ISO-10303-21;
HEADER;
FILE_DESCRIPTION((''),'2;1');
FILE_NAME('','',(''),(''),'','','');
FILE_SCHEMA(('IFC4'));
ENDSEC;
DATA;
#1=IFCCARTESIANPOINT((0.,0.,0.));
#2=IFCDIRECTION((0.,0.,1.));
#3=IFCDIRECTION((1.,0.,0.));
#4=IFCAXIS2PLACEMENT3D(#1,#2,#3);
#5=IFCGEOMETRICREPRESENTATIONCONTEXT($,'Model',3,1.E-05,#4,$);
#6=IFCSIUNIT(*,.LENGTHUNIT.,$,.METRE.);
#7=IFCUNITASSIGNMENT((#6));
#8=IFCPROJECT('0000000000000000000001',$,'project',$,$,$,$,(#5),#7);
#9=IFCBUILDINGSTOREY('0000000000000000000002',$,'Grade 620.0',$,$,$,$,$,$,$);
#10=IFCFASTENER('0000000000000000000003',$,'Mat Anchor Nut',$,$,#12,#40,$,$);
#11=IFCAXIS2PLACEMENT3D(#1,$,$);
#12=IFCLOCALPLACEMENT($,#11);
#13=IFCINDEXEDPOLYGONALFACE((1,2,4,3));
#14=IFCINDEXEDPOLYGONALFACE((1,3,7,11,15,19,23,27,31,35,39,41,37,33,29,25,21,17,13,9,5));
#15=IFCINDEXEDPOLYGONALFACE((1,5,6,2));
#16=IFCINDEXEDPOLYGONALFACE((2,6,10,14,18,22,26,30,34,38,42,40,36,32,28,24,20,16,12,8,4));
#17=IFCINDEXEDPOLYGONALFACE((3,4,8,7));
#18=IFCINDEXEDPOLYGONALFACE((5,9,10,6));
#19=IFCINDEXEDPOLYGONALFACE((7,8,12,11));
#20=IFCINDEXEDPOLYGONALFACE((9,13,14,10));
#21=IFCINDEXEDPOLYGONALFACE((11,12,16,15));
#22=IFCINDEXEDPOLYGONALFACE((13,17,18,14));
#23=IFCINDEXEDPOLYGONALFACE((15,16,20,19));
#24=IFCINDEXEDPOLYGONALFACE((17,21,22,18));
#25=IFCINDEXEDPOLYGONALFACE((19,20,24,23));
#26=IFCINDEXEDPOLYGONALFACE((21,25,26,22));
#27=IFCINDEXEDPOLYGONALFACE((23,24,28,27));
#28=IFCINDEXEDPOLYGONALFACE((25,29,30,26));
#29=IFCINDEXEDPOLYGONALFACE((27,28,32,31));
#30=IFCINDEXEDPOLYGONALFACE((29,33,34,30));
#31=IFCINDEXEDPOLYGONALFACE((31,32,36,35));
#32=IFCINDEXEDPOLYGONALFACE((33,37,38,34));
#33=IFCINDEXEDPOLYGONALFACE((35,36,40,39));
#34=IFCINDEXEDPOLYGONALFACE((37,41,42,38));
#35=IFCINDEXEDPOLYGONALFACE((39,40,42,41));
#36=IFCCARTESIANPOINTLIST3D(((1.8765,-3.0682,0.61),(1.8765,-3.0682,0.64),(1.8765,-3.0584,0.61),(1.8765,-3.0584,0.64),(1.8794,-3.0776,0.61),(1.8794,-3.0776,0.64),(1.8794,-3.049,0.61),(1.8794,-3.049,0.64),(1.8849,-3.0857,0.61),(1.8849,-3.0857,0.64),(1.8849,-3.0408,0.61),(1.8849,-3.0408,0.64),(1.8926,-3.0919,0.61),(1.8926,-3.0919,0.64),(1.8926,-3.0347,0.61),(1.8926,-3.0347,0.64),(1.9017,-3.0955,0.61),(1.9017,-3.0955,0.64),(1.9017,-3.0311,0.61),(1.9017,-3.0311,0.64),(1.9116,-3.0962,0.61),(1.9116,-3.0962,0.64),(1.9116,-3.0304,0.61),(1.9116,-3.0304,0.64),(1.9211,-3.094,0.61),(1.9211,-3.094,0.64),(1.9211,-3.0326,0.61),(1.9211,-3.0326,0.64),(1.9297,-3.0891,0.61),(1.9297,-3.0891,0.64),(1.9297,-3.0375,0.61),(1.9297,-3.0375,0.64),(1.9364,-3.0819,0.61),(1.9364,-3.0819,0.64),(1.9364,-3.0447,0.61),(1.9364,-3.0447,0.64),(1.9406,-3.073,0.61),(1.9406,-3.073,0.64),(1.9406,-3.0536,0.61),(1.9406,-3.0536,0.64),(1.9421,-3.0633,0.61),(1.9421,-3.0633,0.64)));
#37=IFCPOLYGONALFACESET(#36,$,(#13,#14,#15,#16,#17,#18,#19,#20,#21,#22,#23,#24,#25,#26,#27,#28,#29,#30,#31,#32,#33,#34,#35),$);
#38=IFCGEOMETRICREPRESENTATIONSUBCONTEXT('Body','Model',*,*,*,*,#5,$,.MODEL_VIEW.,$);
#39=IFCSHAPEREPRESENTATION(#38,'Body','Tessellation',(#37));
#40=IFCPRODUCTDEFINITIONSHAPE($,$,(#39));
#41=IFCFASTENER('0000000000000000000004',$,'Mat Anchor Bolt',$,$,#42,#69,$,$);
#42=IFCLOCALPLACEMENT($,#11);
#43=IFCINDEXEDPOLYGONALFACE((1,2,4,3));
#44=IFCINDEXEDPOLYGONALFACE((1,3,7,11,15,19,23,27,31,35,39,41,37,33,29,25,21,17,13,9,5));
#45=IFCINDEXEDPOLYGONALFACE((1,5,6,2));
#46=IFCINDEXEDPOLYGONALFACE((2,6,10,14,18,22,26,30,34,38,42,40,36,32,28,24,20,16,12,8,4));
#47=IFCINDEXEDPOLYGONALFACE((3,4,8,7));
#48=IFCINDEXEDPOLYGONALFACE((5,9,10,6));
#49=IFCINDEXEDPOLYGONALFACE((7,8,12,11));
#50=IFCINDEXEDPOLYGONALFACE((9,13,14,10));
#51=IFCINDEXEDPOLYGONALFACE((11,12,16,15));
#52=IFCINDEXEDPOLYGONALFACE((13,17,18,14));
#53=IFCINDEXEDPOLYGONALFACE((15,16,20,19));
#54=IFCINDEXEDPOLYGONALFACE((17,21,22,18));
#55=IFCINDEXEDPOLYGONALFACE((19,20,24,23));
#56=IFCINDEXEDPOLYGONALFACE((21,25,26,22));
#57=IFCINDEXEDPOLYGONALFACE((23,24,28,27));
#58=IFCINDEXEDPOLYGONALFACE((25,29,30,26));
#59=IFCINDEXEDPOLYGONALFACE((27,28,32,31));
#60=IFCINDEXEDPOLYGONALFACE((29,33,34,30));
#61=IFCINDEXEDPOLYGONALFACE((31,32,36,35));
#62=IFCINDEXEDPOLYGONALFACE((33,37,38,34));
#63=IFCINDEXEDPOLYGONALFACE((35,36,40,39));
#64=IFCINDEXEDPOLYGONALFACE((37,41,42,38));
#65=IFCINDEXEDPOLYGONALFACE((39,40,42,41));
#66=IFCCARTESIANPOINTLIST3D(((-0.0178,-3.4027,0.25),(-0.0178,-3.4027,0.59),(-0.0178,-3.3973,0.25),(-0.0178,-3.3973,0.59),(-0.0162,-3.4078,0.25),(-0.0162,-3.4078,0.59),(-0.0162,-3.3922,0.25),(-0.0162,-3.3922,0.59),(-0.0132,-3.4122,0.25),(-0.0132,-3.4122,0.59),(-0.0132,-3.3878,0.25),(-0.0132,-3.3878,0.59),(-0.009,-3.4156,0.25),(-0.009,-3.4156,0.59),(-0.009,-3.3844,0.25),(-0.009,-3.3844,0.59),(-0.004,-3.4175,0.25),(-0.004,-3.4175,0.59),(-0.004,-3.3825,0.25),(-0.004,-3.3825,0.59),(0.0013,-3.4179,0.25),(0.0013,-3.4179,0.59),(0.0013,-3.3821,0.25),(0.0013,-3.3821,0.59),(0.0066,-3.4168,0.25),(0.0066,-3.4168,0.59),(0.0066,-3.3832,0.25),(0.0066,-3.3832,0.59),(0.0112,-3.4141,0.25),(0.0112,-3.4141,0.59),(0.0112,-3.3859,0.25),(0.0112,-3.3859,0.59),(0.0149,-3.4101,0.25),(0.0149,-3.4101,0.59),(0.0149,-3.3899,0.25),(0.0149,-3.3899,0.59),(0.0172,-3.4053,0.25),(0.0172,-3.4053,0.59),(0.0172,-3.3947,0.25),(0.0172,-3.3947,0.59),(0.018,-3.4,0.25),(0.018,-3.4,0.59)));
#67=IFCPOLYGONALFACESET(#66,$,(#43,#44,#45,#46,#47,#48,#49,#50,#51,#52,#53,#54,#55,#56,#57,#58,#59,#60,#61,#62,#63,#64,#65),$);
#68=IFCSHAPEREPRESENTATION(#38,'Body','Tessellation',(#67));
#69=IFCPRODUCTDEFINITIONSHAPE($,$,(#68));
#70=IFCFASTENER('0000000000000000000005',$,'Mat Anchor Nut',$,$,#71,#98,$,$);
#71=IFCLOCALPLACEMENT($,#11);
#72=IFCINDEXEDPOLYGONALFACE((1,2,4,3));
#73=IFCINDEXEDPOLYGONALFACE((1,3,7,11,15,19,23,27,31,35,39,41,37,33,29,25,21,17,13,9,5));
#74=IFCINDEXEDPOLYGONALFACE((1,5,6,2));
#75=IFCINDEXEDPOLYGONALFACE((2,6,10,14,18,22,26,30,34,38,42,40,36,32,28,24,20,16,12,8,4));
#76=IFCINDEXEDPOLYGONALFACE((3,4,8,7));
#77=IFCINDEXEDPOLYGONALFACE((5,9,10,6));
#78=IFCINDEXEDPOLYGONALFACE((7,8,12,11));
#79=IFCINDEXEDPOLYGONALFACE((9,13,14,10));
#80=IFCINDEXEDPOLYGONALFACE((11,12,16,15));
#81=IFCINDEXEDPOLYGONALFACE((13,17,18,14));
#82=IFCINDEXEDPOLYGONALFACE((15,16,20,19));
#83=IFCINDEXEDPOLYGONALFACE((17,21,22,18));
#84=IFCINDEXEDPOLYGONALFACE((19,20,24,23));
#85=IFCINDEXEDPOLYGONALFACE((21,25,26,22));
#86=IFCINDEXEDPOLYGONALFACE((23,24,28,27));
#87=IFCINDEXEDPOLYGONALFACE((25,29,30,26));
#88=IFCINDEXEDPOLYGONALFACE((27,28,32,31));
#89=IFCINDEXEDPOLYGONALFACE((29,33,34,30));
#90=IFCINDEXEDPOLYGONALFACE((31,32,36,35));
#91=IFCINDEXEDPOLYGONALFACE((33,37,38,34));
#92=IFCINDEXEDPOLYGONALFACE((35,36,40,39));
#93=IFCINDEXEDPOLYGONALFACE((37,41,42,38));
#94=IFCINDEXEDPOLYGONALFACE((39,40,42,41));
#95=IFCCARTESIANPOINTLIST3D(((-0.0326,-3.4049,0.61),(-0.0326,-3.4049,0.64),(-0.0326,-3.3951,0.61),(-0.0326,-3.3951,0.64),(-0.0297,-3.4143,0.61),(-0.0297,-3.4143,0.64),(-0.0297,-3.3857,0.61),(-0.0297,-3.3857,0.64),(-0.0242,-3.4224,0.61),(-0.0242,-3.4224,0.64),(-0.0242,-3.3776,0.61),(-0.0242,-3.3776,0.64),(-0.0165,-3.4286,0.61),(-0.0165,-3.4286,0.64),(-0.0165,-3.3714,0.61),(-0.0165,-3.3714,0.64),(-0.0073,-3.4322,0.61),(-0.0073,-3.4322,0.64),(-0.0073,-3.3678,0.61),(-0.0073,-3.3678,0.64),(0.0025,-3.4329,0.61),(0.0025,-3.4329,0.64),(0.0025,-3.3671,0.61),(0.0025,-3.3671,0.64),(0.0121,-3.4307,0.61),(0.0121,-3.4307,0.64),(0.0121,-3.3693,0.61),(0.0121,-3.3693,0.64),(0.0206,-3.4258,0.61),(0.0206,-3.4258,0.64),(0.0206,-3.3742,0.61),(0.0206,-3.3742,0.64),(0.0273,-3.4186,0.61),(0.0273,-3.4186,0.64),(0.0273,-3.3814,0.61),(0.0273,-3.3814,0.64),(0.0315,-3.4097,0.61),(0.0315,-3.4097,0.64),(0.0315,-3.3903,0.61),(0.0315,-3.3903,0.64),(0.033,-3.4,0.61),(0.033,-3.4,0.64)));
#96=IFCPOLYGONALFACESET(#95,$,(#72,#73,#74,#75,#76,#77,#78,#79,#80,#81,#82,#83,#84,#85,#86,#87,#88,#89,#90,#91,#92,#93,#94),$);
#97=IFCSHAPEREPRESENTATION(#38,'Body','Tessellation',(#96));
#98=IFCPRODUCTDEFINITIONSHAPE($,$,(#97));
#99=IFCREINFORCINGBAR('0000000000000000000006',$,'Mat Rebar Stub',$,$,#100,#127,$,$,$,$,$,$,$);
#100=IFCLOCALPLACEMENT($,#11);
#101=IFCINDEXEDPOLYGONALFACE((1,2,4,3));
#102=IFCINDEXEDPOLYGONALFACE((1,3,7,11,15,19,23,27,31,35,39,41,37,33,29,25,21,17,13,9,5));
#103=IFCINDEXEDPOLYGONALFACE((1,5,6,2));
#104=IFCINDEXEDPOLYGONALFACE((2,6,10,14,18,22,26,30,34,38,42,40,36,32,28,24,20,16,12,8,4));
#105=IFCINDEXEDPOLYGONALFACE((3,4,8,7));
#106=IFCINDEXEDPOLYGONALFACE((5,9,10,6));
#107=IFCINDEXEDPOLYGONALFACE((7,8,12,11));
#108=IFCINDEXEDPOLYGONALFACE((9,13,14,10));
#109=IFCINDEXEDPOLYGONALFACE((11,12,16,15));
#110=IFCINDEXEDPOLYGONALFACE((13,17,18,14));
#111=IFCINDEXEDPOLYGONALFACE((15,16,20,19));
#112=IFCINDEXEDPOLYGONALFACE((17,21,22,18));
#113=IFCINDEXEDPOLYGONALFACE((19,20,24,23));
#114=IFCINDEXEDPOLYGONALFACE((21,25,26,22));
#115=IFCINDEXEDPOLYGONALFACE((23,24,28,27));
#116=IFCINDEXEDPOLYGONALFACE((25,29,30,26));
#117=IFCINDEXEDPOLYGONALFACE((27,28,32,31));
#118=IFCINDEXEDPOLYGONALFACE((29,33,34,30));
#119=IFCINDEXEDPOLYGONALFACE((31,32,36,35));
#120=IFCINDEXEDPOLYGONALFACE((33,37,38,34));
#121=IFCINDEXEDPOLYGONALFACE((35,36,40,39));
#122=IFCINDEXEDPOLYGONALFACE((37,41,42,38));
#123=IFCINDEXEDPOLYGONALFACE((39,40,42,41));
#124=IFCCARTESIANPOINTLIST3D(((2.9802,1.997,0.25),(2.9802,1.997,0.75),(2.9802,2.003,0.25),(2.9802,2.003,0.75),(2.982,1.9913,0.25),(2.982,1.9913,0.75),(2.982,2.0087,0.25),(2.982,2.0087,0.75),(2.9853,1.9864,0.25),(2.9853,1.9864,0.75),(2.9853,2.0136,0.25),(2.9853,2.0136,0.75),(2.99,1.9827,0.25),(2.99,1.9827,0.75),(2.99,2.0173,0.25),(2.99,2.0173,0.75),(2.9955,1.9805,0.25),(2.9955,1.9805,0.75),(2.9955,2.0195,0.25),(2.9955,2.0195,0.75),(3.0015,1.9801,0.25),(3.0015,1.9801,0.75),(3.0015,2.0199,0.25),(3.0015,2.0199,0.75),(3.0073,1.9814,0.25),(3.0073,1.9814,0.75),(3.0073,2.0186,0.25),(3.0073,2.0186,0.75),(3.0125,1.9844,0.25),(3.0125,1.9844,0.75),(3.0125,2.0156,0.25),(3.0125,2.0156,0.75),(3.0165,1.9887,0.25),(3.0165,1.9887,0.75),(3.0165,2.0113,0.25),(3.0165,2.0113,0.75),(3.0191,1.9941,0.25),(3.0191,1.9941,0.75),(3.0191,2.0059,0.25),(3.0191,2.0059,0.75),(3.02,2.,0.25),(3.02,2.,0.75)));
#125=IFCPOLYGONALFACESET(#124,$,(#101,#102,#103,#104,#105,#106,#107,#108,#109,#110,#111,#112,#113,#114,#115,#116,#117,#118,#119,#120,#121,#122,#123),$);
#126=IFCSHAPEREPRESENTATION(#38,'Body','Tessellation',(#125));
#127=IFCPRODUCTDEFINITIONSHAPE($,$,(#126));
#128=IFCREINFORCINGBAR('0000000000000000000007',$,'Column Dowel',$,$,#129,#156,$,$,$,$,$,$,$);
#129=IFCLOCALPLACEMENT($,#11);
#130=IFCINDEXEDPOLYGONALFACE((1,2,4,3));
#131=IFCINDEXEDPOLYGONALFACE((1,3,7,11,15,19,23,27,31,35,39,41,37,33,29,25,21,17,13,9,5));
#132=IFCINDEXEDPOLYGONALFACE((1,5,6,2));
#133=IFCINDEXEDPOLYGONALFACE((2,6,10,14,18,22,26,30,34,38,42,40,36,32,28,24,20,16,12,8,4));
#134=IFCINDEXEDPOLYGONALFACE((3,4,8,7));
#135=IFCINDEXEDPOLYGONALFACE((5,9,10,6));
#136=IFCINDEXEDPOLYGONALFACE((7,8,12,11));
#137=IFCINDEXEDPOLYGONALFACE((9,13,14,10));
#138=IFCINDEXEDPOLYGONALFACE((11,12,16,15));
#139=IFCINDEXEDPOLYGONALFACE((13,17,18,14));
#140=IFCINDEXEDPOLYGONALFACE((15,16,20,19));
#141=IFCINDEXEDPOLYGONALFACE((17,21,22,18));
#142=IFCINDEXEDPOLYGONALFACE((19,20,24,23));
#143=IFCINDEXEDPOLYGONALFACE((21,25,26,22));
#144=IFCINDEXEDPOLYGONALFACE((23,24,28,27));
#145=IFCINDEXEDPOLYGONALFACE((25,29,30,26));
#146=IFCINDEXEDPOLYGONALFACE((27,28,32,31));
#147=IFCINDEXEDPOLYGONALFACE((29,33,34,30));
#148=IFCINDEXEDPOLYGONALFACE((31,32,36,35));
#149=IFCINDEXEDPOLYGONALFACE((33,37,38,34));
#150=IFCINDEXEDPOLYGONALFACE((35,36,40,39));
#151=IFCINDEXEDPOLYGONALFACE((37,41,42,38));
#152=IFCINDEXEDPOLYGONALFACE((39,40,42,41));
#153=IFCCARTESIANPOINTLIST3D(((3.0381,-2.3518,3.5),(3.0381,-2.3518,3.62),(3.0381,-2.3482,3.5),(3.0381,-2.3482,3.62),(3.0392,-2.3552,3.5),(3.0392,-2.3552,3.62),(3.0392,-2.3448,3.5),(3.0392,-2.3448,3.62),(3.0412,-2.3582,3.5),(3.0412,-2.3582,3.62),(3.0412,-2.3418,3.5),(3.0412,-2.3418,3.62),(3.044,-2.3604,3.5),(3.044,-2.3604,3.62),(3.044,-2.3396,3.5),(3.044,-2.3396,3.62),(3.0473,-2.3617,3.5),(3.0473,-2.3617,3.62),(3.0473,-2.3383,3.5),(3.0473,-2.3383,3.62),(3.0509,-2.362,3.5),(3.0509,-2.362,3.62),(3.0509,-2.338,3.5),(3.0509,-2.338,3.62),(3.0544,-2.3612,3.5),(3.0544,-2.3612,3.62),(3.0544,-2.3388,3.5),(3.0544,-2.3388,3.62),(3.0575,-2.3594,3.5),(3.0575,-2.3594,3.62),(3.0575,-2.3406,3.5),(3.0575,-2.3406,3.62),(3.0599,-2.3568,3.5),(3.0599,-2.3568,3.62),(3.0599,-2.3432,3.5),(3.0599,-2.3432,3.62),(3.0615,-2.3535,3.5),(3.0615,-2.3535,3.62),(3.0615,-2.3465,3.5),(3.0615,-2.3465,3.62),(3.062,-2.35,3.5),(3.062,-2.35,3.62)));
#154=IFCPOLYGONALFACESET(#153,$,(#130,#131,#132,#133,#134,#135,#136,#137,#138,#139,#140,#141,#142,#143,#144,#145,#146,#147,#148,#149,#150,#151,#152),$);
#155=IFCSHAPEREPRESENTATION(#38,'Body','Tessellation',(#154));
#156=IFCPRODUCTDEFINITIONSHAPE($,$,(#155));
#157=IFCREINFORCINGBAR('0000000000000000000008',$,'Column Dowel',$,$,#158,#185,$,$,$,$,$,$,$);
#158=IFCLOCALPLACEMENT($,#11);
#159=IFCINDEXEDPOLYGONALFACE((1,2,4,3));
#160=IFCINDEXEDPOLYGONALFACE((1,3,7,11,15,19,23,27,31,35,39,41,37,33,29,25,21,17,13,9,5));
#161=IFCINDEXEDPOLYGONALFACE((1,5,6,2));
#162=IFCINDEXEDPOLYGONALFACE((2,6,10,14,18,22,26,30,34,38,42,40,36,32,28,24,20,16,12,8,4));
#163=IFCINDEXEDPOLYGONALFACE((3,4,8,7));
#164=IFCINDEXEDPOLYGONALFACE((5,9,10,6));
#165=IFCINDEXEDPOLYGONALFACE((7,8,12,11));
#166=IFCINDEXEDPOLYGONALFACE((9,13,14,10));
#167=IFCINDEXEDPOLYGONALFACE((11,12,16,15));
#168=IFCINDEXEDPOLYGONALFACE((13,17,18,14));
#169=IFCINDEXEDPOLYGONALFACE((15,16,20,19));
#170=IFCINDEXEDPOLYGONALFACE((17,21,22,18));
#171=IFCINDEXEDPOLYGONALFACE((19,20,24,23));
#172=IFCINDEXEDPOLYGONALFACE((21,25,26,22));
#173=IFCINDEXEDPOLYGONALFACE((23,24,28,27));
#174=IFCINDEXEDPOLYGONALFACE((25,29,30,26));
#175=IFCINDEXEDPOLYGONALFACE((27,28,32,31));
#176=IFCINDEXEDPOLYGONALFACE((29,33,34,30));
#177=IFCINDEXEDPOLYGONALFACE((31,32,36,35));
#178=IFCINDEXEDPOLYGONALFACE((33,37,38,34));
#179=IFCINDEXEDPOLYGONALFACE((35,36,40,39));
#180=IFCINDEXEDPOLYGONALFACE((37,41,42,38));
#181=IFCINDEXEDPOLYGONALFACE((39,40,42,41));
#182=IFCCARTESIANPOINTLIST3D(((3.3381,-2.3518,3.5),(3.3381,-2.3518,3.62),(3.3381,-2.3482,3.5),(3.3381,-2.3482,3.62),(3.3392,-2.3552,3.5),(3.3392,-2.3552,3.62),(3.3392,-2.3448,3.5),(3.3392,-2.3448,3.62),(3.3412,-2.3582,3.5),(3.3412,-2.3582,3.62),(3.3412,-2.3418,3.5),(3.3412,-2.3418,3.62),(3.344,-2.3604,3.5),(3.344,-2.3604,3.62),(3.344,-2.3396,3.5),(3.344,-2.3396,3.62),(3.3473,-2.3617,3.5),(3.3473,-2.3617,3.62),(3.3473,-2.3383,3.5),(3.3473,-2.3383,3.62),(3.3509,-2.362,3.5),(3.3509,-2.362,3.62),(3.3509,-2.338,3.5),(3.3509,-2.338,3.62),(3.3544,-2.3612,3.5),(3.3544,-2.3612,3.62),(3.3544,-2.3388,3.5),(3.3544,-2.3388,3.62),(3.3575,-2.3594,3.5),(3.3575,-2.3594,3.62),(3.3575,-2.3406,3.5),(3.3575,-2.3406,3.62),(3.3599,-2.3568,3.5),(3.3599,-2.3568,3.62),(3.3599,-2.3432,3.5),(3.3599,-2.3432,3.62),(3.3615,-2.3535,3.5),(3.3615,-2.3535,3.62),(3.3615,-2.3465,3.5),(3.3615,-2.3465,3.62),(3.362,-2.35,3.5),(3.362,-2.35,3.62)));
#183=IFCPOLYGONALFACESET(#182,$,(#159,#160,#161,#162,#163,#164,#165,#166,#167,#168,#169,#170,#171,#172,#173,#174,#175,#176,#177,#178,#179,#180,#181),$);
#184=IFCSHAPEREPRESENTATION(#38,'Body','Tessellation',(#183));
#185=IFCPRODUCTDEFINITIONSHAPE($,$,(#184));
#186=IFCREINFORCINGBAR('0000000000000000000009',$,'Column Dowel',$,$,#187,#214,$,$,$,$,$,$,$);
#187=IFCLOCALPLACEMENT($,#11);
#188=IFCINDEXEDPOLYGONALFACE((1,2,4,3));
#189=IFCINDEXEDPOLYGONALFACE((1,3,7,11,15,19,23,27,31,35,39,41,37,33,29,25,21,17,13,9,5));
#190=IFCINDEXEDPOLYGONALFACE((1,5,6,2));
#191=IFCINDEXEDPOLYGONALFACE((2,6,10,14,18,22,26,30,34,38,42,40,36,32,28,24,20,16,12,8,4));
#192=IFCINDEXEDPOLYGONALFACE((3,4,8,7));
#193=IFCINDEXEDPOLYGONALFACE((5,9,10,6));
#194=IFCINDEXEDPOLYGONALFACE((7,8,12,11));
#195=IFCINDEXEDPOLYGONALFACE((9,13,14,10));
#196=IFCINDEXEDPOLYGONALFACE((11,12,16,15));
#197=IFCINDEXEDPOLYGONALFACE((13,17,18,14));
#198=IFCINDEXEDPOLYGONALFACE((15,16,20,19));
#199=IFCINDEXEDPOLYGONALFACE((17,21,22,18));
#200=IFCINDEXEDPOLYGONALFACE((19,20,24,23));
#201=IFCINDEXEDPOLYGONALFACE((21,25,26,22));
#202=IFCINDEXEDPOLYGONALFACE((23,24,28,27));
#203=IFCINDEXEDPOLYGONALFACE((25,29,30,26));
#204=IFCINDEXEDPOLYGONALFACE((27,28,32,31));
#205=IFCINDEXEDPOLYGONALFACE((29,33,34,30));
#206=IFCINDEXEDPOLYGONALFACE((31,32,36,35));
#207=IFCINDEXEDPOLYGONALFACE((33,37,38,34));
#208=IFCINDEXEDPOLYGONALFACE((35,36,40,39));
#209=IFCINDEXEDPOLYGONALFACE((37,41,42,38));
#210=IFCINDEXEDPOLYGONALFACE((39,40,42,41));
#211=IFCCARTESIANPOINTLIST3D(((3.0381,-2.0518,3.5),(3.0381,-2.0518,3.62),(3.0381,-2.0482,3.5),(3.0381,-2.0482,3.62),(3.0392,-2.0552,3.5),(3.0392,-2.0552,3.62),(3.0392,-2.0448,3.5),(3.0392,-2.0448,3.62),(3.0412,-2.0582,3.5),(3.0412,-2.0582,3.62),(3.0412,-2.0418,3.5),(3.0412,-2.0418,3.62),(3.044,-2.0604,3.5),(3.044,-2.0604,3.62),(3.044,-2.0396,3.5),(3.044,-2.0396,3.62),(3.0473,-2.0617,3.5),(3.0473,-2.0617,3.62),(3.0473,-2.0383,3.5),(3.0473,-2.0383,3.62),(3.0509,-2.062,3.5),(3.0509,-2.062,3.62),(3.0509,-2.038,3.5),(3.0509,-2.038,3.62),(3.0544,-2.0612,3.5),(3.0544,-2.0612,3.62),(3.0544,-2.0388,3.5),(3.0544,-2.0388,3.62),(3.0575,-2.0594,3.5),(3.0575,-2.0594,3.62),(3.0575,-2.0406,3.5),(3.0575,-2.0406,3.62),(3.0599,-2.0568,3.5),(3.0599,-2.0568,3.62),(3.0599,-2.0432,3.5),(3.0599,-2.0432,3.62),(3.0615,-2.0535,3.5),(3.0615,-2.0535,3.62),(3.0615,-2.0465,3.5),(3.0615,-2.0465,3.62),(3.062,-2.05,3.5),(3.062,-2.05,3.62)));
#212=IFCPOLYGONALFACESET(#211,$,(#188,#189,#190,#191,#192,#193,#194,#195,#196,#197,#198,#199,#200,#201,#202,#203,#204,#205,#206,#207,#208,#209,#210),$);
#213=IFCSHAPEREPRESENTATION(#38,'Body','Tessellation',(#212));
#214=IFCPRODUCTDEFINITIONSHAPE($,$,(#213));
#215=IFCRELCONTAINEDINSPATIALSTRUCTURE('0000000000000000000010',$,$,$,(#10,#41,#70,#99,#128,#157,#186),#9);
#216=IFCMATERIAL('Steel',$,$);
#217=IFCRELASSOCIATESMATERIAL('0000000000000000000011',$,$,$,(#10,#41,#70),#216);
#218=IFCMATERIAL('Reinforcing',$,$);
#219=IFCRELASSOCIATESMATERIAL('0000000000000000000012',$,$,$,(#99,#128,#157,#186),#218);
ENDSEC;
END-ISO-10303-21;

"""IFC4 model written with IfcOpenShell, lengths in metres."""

from ifc_helpers import new_model, si_unit, frame, origin_with_axes, place, context, subcontext, project, spatial, circle, extrude, material, element, save


model = new_model("IFC4")

# Units and contexts
model_context = context("Model", 3, precision=1e-05, world=origin_with_axes())
body_context = subcontext(model_context, "Body", "Model", "MODEL_VIEW")
ifc_project = project(units=[si_unit("LENGTHUNIT", "METRE")], contexts=[model_context])

# Storey
storey = spatial("IfcBuildingStorey", Name="Grade 620.0")

# Fasteners
ifc_material_1 = material(Name="Steel")
fastener_1_placement = place(None, frame((1.9091, -3.0633, 0.61), z_axis=(0.0, 0.0, 1.0), x_axis=(1.0, 0.0, 0.0)))
element("IfcFastener", 1, at=fastener_1_placement, inside=storey, material=ifc_material_1, Name="Mat Anchor Nut", context=body_context, shape_type="SweptSolid", body=[
    extrude(circle(Radius=0.033), origin_with_axes(), (0.0, 0.0, 1.0), 0.03),
])
fastener_2_placement = place(None, frame((0.0, -3.4, 0.25), z_axis=(0.0, 0.0, 1.0), x_axis=(1.0, 0.0, 0.0)))
element("IfcFastener", 2, at=fastener_2_placement, inside=storey, material=ifc_material_1, Name="Mat Anchor Bolt", context=body_context, shape_type="SweptSolid", body=[
    extrude(circle(Radius=0.018), origin_with_axes(), (0.0, 0.0, 1.0), 0.34),
])
fastener_3_placement = place(None, frame((0.0, -3.4, 0.61), z_axis=(0.0, 0.0, 1.0), x_axis=(1.0, 0.0, 0.0)))
element("IfcFastener", 3, at=fastener_3_placement, inside=storey, material=ifc_material_1, Name="Mat Anchor Nut", context=body_context, shape_type="SweptSolid", body=[
    extrude(circle(Radius=0.033), origin_with_axes(), (0.0, 0.0, 1.0), 0.03),
])

# Reinforcing bars
ifc_material_2 = material(Name="Reinforcing")
reinforcing_bar_placement = place(None, frame((3.0, 2.0, 0.25), z_axis=(0.0, 0.0, 1.0), x_axis=(1.0, 0.0, 0.0)))
element("IfcReinforcingBar", 4, at=reinforcing_bar_placement, inside=storey, material=ifc_material_2, Name="Mat Rebar Stub", context=body_context, shape_type="SweptSolid", body=[
    extrude(circle(Radius=0.02), origin_with_axes(), (0.0, 0.0, 1.0), 0.5),
])
for number, where, z_axis, x_axis, name in (
    (5, (3.05, -2.35, 3.5), (0.0, 0.0, 1.0), (1.0, 0.0, 0.0), "Column Dowel"),
    (6, (3.35, -2.35, 3.5), (0.0, 0.0, 1.0), (1.0, 0.0, 0.0), "Column Dowel"),
    (7, (3.05, -2.05, 3.5), (0.0, 0.0, 1.0), (1.0, 0.0, 0.0), "Column Dowel"),
):
    element("IfcReinforcingBar", number, at=place(None, frame(where, z_axis=z_axis, x_axis=x_axis)), inside=storey, material=ifc_material_2, Name=name, context=body_context, shape_type="SweptSolid", body=[
        extrude(circle(Radius=0.012), origin_with_axes(), (0.0, 0.0, 1.0), 0.12),
    ])

save(model, "model.ifc")
